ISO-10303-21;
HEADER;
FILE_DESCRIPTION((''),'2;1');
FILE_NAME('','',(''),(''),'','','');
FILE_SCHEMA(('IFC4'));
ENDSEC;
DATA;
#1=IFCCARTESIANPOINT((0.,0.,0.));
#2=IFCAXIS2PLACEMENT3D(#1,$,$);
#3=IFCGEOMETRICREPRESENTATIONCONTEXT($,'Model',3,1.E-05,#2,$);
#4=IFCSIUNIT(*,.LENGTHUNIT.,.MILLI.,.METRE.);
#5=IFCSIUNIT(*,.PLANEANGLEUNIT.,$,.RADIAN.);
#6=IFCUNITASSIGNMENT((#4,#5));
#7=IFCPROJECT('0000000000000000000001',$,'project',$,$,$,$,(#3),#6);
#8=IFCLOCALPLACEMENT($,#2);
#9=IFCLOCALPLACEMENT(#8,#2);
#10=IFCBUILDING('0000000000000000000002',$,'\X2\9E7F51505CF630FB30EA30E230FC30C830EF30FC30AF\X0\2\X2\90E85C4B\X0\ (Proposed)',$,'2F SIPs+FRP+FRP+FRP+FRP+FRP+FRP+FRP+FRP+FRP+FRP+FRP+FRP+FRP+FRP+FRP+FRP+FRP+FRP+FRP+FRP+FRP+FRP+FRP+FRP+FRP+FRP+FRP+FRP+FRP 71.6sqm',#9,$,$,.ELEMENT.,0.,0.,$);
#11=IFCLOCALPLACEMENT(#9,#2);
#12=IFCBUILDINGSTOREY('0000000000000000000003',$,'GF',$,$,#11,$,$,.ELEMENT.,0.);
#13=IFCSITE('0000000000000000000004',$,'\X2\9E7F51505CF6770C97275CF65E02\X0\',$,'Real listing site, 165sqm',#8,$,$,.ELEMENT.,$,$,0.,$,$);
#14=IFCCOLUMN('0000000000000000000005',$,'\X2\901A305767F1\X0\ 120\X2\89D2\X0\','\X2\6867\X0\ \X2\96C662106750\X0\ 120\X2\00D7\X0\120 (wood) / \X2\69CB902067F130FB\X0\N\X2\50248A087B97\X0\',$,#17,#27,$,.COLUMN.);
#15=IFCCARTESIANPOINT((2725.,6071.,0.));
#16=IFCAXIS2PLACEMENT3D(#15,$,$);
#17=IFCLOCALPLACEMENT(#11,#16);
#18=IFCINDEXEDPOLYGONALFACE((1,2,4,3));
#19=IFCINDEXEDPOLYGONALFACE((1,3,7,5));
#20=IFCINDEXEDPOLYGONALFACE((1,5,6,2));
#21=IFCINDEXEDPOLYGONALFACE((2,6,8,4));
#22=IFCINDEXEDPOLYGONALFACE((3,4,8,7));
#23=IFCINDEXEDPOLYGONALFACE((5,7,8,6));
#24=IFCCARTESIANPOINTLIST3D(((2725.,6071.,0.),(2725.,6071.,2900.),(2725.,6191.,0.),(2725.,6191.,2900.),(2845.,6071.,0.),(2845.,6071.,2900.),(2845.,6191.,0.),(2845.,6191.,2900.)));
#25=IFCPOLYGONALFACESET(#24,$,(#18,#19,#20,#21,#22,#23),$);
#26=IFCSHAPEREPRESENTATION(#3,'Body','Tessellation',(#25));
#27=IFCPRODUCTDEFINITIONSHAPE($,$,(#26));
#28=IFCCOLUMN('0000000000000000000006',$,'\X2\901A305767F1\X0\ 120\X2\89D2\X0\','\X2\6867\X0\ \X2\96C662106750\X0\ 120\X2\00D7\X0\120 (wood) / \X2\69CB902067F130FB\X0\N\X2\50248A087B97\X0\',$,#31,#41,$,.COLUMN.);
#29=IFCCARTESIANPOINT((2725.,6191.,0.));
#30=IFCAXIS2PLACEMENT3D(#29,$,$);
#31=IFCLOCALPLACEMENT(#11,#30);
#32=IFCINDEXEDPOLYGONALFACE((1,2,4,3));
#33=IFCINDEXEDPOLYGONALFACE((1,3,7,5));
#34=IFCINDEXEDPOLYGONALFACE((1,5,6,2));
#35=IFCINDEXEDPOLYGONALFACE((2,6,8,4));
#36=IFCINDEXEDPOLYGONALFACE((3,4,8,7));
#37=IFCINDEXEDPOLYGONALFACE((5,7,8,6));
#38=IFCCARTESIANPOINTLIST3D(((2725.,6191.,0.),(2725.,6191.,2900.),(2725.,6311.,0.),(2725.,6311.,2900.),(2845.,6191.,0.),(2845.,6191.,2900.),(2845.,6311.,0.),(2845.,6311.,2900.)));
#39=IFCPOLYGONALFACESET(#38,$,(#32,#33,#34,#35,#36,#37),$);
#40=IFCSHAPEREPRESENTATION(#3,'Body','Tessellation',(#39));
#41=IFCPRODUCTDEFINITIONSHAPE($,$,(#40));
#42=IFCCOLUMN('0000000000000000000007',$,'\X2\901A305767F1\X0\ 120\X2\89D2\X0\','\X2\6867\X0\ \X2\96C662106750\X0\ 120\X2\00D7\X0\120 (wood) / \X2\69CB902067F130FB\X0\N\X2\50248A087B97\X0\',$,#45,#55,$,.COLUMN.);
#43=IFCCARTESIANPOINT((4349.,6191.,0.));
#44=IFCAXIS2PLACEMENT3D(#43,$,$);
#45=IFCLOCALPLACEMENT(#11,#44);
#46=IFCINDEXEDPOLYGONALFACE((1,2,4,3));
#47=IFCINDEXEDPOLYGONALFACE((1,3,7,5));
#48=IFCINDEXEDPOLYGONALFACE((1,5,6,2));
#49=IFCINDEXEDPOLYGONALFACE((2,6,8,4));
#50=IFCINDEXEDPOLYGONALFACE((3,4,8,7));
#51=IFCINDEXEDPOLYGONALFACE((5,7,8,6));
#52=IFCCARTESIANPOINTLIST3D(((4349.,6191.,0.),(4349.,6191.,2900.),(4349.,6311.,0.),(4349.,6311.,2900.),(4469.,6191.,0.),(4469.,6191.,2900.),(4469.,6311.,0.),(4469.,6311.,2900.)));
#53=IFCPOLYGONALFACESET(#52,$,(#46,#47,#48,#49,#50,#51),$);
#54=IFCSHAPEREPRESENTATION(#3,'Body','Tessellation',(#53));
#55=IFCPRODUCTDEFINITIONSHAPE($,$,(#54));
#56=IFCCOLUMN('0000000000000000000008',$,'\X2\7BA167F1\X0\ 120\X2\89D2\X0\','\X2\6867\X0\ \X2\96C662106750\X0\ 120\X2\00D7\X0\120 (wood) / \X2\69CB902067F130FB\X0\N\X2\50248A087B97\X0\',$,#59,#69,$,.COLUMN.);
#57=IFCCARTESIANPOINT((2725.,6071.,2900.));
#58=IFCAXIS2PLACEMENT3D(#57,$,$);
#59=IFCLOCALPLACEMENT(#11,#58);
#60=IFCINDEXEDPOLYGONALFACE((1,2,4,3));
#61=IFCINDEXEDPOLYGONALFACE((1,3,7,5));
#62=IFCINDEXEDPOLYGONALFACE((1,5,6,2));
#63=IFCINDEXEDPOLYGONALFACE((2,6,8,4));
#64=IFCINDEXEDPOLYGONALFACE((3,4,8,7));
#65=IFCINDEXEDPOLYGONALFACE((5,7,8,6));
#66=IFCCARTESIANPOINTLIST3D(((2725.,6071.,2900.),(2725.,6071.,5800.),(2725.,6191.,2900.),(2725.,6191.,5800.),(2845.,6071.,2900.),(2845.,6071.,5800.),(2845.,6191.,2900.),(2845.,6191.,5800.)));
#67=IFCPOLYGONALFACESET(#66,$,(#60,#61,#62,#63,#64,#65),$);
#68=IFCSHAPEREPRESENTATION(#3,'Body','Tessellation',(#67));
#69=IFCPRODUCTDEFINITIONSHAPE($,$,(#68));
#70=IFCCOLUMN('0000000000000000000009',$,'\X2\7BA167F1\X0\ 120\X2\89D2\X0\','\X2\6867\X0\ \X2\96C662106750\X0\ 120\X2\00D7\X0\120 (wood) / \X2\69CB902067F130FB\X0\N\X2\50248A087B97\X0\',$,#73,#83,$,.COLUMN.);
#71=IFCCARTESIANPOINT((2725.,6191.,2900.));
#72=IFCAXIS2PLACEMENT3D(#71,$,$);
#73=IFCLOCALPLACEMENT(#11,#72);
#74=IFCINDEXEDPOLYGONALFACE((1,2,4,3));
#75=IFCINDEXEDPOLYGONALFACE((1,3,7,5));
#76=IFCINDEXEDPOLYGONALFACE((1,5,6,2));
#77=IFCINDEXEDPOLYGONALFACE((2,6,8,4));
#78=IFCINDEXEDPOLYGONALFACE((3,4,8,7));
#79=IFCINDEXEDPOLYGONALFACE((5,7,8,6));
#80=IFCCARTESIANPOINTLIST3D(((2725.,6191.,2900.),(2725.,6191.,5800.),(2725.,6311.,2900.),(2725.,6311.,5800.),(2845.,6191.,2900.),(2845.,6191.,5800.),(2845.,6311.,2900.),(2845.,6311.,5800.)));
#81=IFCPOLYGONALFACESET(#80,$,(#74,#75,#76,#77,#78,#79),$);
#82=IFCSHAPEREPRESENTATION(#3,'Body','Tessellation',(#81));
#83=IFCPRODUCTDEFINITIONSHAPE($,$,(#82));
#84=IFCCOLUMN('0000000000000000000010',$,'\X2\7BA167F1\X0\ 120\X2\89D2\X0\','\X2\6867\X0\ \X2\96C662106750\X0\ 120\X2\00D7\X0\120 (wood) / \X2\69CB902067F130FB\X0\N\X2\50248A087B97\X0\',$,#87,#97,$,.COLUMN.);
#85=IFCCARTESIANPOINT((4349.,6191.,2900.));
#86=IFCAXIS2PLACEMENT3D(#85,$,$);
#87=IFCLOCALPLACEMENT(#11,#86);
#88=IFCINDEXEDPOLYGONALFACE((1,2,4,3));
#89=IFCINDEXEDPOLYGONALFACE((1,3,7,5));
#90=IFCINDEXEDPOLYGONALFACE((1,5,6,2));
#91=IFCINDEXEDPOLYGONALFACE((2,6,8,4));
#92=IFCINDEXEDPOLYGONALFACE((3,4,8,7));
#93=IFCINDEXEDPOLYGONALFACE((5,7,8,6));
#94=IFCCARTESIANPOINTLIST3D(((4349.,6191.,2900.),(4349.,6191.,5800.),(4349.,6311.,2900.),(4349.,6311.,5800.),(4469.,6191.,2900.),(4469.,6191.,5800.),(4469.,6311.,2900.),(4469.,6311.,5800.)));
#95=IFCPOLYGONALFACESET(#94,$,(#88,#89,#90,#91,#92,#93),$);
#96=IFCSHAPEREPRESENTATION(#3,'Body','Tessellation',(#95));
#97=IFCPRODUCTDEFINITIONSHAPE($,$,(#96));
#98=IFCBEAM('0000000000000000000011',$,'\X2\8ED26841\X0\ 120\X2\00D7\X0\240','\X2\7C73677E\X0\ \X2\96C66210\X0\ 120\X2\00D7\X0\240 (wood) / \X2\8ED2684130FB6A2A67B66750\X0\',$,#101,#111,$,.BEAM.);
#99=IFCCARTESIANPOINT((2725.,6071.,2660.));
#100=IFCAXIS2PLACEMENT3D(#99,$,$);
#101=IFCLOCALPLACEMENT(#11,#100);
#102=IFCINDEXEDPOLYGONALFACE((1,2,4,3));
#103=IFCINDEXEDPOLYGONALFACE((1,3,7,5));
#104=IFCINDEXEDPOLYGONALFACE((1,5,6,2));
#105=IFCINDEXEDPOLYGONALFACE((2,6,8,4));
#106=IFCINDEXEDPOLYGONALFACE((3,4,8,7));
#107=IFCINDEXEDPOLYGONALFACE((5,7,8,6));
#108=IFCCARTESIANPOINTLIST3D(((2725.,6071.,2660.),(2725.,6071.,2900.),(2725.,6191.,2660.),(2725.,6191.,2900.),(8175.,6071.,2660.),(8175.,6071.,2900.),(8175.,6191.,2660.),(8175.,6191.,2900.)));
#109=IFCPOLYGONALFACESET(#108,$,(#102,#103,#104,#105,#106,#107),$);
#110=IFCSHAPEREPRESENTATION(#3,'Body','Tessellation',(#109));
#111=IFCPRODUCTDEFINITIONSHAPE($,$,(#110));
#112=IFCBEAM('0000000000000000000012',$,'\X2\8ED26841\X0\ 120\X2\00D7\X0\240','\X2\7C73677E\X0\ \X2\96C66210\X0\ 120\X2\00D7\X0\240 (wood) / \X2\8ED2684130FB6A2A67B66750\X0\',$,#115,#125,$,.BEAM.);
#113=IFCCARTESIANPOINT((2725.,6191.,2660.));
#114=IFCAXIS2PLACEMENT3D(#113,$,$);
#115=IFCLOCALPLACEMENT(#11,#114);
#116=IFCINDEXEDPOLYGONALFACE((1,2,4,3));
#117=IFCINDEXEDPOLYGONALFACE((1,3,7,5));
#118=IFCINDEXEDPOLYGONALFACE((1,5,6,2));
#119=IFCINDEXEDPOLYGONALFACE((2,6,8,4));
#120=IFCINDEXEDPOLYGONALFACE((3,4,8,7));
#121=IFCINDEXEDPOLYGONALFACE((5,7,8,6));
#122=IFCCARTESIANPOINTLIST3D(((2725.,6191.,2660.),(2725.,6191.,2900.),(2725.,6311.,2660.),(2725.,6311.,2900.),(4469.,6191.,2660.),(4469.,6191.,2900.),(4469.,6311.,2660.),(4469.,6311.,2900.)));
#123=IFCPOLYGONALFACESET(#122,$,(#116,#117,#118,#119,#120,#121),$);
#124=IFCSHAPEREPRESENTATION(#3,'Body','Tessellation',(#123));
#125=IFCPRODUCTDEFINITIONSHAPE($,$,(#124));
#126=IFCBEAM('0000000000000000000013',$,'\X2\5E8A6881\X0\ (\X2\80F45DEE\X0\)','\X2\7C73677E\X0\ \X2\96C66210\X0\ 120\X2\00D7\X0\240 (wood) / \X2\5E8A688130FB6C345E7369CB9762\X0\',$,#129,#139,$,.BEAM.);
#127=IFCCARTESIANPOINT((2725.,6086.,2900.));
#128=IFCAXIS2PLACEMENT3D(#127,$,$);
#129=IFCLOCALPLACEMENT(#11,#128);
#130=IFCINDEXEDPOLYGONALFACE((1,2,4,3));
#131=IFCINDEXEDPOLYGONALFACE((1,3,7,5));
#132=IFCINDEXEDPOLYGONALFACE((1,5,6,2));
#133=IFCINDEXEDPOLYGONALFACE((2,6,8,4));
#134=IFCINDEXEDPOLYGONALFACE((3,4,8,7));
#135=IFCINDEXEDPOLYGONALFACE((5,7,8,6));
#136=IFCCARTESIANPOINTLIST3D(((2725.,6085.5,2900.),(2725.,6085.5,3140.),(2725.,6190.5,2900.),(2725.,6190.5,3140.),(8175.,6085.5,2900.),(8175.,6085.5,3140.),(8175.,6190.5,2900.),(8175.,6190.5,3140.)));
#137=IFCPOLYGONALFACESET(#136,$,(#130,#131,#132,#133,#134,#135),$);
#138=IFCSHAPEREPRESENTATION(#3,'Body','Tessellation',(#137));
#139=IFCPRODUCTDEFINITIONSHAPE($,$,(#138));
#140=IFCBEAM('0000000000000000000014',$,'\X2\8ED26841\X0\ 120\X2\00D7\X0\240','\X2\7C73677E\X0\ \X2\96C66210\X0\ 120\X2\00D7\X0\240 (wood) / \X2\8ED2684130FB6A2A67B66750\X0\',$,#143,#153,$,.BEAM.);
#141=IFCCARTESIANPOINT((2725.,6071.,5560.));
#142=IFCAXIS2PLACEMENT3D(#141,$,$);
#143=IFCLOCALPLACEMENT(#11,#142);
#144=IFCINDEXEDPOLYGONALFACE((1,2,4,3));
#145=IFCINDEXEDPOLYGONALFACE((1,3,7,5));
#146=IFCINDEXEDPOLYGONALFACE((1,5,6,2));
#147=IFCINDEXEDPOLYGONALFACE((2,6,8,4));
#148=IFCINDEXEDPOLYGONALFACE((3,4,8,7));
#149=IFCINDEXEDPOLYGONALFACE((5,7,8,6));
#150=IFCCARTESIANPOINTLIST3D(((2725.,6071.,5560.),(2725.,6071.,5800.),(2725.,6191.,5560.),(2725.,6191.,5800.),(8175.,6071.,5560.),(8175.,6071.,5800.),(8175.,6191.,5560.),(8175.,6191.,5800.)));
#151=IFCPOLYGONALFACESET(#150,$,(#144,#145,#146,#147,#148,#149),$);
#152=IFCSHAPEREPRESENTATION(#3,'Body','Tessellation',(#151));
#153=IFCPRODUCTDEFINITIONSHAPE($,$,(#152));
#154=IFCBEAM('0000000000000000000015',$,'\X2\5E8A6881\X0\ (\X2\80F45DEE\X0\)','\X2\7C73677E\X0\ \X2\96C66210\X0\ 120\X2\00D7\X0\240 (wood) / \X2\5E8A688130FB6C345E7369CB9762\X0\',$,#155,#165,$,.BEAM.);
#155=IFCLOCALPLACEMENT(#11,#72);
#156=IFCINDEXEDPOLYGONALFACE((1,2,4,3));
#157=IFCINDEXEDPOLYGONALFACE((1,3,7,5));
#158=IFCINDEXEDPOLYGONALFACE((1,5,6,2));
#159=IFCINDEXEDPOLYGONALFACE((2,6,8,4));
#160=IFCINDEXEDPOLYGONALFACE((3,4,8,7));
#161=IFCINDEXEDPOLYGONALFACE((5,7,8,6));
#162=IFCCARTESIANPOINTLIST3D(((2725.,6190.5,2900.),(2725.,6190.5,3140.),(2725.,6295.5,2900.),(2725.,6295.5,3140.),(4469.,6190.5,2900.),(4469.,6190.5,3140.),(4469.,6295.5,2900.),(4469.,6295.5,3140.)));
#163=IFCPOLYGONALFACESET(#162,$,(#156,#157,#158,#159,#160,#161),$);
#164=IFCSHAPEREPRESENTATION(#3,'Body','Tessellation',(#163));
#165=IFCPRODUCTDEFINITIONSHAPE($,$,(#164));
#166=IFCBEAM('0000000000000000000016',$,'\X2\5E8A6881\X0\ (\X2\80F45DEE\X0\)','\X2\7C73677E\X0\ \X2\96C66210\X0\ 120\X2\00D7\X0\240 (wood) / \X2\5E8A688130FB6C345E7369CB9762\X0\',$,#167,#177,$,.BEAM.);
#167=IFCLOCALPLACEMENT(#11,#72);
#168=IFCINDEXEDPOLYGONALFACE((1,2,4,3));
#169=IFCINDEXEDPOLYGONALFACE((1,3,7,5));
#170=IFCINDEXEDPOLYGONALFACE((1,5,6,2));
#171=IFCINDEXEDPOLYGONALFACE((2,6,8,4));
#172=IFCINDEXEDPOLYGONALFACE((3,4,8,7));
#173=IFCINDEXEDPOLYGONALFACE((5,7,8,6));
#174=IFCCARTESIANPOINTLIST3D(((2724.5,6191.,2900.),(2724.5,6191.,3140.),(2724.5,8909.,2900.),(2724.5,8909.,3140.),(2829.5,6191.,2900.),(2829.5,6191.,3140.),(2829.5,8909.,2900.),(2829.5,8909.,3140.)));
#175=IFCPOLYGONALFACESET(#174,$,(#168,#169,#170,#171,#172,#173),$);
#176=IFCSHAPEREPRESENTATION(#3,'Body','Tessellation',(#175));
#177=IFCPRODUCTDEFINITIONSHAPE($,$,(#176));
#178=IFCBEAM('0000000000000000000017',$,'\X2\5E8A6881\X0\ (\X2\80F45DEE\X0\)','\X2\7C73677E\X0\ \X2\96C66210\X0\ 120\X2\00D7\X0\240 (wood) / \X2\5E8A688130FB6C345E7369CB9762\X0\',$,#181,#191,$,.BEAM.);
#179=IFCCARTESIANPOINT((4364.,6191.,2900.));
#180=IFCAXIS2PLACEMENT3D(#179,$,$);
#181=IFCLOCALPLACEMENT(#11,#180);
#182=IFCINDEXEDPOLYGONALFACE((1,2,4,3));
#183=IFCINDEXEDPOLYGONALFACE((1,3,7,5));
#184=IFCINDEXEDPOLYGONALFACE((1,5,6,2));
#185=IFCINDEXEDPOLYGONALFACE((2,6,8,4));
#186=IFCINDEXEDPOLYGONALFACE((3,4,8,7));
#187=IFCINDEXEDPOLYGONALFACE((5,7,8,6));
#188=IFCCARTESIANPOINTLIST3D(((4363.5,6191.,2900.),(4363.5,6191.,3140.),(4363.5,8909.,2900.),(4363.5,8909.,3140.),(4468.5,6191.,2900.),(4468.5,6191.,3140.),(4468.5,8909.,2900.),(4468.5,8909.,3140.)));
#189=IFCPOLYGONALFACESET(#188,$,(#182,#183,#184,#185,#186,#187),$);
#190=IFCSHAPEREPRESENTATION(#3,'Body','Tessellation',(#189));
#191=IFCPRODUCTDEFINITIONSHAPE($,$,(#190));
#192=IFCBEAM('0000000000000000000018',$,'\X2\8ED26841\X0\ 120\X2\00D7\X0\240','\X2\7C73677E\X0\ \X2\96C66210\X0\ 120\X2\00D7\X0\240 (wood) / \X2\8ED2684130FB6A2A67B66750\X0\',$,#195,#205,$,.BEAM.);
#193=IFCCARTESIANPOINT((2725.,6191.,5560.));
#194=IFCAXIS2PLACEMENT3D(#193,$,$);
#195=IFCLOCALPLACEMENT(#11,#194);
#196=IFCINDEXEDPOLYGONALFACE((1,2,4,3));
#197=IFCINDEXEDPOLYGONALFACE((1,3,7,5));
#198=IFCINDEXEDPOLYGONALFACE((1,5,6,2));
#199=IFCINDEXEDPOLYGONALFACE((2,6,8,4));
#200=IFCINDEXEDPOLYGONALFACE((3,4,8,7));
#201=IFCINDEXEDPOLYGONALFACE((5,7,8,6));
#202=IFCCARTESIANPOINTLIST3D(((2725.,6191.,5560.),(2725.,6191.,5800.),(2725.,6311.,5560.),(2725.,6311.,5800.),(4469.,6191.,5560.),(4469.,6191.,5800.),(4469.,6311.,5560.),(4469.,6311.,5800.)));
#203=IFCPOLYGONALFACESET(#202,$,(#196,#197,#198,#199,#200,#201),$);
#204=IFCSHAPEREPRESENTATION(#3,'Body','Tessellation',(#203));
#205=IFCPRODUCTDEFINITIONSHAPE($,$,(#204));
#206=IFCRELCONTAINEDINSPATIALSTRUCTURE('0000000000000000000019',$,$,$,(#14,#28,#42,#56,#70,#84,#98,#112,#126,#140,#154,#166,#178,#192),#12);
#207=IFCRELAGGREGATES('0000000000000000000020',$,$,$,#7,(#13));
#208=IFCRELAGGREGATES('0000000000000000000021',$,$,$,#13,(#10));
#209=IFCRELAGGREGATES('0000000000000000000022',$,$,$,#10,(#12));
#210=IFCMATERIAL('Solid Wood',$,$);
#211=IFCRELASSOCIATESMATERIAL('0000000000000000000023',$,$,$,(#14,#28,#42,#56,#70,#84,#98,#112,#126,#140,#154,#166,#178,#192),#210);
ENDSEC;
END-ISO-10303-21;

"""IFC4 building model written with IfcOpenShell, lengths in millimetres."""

from ifc_helpers import new_model, si_unit, frame, frame_2d, origin, place, context, project, spatial, rectangle, extrude, material, element, save


model = new_model("IFC4")

# Units and contexts
model_context = context("Model", 3, precision=1e-05, world=origin())
ifc_project = project(units=[si_unit("LENGTHUNIT", "METRE", prefix="MILLI"), si_unit("PLANEANGLEUNIT", "RADIAN")], contexts=[model_context])

# Site, building, storey
site_placement = place(None, origin())
site = spatial("IfcSite", under=ifc_project, at=site_placement, Name="鹿児島県霧島市", ObjectType="Real listing site, 165sqm", CompositionType="ELEMENT", RefElevation=0.0)
building_placement = place(site_placement, origin())
building = spatial("IfcBuilding", under=site, at=building_placement, Name="鹿児島・リモートワーク2部屋 (Proposed)", ObjectType="2F SIPs+FRP+FRP+FRP+FRP+FRP+FRP+FRP+FRP+FRP+FRP+FRP+FRP+FRP+FRP+FRP+FRP+FRP+FRP+FRP+FRP+FRP+FRP+FRP+FRP+FRP+FRP+FRP+FRP+FRP 71.6sqm", CompositionType="ELEMENT", ElevationOfRefHeight=0.0, ElevationOfTerrain=0.0)
storey_placement = place(building_placement, origin())
storey = spatial("IfcBuildingStorey", under=building, at=storey_placement, Name="GF", CompositionType="ELEMENT", Elevation=0.0)

# Columns
ifc_material_1 = material(Name="Solid Wood")
column_1_placement = place(storey_placement, frame((2725.0, 6071.0, 0.0)))
element("IfcColumn", 1, at=column_1_placement, inside=storey, material=ifc_material_1, Name="通し柱 120角", Description="桧 集成材 120×120 (wood) / 構造柱・N値計算", PredefinedType="COLUMN", context=model_context, shape_type="SweptSolid", body=[
    extrude(rectangle(XDim=120.0, YDim=120.0, at=frame_2d((60.0, 60.0))), frame((2725.0, 6071.0, 0.0)), (0.0, 0.0, 1.0), 2900.0),
])
column_2_placement = place(storey_placement, frame((2725.0, 6191.0, 0.0)))
element("IfcColumn", 2, at=column_2_placement, inside=storey, material=ifc_material_1, Name="通し柱 120角", Description="桧 集成材 120×120 (wood) / 構造柱・N値計算", PredefinedType="COLUMN", context=model_context, shape_type="SweptSolid", body=[
    extrude(rectangle(XDim=120.0, YDim=120.0, at=frame_2d((60.0, 60.0))), frame((2725.0, 6191.0, 0.0)), (0.0, 0.0, 1.0), 2900.0),
])
column_3_placement = place(storey_placement, frame((4349.0, 6191.0, 0.0)))
element("IfcColumn", 3, at=column_3_placement, inside=storey, material=ifc_material_1, Name="通し柱 120角", Description="桧 集成材 120×120 (wood) / 構造柱・N値計算", PredefinedType="COLUMN", context=model_context, shape_type="SweptSolid", body=[
    extrude(rectangle(XDim=120.0, YDim=120.0, at=frame_2d((60.0, 60.0))), frame((4349.0, 6191.0, 0.0)), (0.0, 0.0, 1.0), 2900.0),
])
column_4_placement = place(storey_placement, frame((2725.0, 6071.0, 2900.0)))
element("IfcColumn", 4, at=column_4_placement, inside=storey, material=ifc_material_1, Name="管柱 120角", Description="桧 集成材 120×120 (wood) / 構造柱・N値計算", PredefinedType="COLUMN", context=model_context, shape_type="SweptSolid", body=[
    extrude(rectangle(XDim=120.0, YDim=120.0, at=frame_2d((60.0, 60.0))), frame((2725.0, 6071.0, 2900.0)), (0.0, 0.0, 1.0), 2900.0),
])
column_5_placement = place(storey_placement, frame((2725.0, 6191.0, 2900.0)))
element("IfcColumn", 5, at=column_5_placement, inside=storey, material=ifc_material_1, Name="管柱 120角", Description="桧 集成材 120×120 (wood) / 構造柱・N値計算", PredefinedType="COLUMN", context=model_context, shape_type="SweptSolid", body=[
    extrude(rectangle(XDim=120.0, YDim=120.0, at=frame_2d((60.0, 60.0))), frame((2725.0, 6191.0, 2900.0)), (0.0, 0.0, 1.0), 2900.0),
])
column_6_placement = place(storey_placement, frame((4349.0, 6191.0, 2900.0)))
element("IfcColumn", 6, at=column_6_placement, inside=storey, material=ifc_material_1, Name="管柱 120角", Description="桧 集成材 120×120 (wood) / 構造柱・N値計算", PredefinedType="COLUMN", context=model_context, shape_type="SweptSolid", body=[
    extrude(rectangle(XDim=120.0, YDim=120.0, at=frame_2d((60.0, 60.0))), frame((4349.0, 6191.0, 2900.0)), (0.0, 0.0, 1.0), 2900.0),
])

# Beams
beam_1_placement = place(storey_placement, frame((2725.0, 6071.0, 2660.0)))
element("IfcBeam", 7, at=beam_1_placement, inside=storey, material=ifc_material_1, Name="軒桁 120×240", Description="米松 集成 120×240 (wood) / 軒桁・横架材", PredefinedType="BEAM", context=model_context, shape_type="SweptSolid", body=[
    extrude(rectangle(XDim=5450.0, YDim=120.0, at=frame_2d((2725.0, 60.0))), frame((2725.0, 6071.0, 2660.0)), (0.0, 0.0, 1.0), 240.0),
])
beam_2_placement = place(storey_placement, frame((2725.0, 6191.0, 2660.0)))
element("IfcBeam", 8, at=beam_2_placement, inside=storey, material=ifc_material_1, Name="軒桁 120×240", Description="米松 集成 120×240 (wood) / 軒桁・横架材", PredefinedType="BEAM", context=model_context, shape_type="SweptSolid", body=[
    extrude(rectangle(XDim=1744.0, YDim=120.0, at=frame_2d((872.0, 60.0))), frame((2725.0, 6191.0, 2660.0)), (0.0, 0.0, 1.0), 240.0),
])
beam_3_placement = place(storey_placement, frame((2725.0, 6086.0, 2900.0)))
element("IfcBeam", 9, at=beam_3_placement, inside=storey, material=ifc_material_1, Name="床梁 (胴差)", Description="米松 集成 120×240 (wood) / 床梁・水平構面", PredefinedType="BEAM", context=model_context, shape_type="SweptSolid", body=[
    extrude(rectangle(XDim=5450.0, YDim=105.0, at=frame_2d((2725.0, 52.0))), frame((2725.0, 6086.0, 2900.0)), (0.0, 0.0, 1.0), 240.0),
])
beam_4_placement = place(storey_placement, frame((2725.0, 6071.0, 5560.0)))
element("IfcBeam", 10, at=beam_4_placement, inside=storey, material=ifc_material_1, Name="軒桁 120×240", Description="米松 集成 120×240 (wood) / 軒桁・横架材", PredefinedType="BEAM", context=model_context, shape_type="SweptSolid", body=[
    extrude(rectangle(XDim=5450.0, YDim=120.0, at=frame_2d((2725.0, 60.0))), frame((2725.0, 6071.0, 5560.0)), (0.0, 0.0, 1.0), 240.0),
])
beam_5_placement = place(storey_placement, frame((2725.0, 6191.0, 2900.0)))
element("IfcBeam", 11, at=beam_5_placement, inside=storey, material=ifc_material_1, Name="床梁 (胴差)", Description="米松 集成 120×240 (wood) / 床梁・水平構面", PredefinedType="BEAM", context=model_context, shape_type="SweptSolid", body=[
    extrude(rectangle(XDim=1744.0, YDim=105.0, at=frame_2d((872.0, 52.0))), frame((2725.0, 6191.0, 2900.0)), (0.0, 0.0, 1.0), 240.0),
])
beam_6_placement = place(storey_placement, frame((2725.0, 6191.0, 2900.0)))
element("IfcBeam", 12, at=beam_6_placement, inside=storey, material=ifc_material_1, Name="床梁 (胴差)", Description="米松 集成 120×240 (wood) / 床梁・水平構面", PredefinedType="BEAM", context=model_context, shape_type="SweptSolid", body=[
    extrude(rectangle(XDim=105.0, YDim=2718.0, at=frame_2d((52.0, 1359.0))), frame((2725.0, 6191.0, 2900.0)), (0.0, 0.0, 1.0), 240.0),
])
beam_7_placement = place(storey_placement, frame((4364.0, 6191.0, 2900.0)))
element("IfcBeam", 13, at=beam_7_placement, inside=storey, material=ifc_material_1, Name="床梁 (胴差)", Description="米松 集成 120×240 (wood) / 床梁・水平構面", PredefinedType="BEAM", context=model_context, shape_type="SweptSolid", body=[
    extrude(rectangle(XDim=105.0, YDim=2718.0, at=frame_2d((52.0, 1359.0))), frame((4364.0, 6191.0, 2900.0)), (0.0, 0.0, 1.0), 240.0),
])
beam_8_placement = place(storey_placement, frame((2725.0, 6191.0, 5560.0)))
element("IfcBeam", 14, at=beam_8_placement, inside=storey, material=ifc_material_1, Name="軒桁 120×240", Description="米松 集成 120×240 (wood) / 軒桁・横架材", PredefinedType="BEAM", context=model_context, shape_type="SweptSolid", body=[
    extrude(rectangle(XDim=1744.0, YDim=120.0, at=frame_2d((872.0, 60.0))), frame((2725.0, 6191.0, 5560.0)), (0.0, 0.0, 1.0), 240.0),
])

save(model, "model.ifc")
